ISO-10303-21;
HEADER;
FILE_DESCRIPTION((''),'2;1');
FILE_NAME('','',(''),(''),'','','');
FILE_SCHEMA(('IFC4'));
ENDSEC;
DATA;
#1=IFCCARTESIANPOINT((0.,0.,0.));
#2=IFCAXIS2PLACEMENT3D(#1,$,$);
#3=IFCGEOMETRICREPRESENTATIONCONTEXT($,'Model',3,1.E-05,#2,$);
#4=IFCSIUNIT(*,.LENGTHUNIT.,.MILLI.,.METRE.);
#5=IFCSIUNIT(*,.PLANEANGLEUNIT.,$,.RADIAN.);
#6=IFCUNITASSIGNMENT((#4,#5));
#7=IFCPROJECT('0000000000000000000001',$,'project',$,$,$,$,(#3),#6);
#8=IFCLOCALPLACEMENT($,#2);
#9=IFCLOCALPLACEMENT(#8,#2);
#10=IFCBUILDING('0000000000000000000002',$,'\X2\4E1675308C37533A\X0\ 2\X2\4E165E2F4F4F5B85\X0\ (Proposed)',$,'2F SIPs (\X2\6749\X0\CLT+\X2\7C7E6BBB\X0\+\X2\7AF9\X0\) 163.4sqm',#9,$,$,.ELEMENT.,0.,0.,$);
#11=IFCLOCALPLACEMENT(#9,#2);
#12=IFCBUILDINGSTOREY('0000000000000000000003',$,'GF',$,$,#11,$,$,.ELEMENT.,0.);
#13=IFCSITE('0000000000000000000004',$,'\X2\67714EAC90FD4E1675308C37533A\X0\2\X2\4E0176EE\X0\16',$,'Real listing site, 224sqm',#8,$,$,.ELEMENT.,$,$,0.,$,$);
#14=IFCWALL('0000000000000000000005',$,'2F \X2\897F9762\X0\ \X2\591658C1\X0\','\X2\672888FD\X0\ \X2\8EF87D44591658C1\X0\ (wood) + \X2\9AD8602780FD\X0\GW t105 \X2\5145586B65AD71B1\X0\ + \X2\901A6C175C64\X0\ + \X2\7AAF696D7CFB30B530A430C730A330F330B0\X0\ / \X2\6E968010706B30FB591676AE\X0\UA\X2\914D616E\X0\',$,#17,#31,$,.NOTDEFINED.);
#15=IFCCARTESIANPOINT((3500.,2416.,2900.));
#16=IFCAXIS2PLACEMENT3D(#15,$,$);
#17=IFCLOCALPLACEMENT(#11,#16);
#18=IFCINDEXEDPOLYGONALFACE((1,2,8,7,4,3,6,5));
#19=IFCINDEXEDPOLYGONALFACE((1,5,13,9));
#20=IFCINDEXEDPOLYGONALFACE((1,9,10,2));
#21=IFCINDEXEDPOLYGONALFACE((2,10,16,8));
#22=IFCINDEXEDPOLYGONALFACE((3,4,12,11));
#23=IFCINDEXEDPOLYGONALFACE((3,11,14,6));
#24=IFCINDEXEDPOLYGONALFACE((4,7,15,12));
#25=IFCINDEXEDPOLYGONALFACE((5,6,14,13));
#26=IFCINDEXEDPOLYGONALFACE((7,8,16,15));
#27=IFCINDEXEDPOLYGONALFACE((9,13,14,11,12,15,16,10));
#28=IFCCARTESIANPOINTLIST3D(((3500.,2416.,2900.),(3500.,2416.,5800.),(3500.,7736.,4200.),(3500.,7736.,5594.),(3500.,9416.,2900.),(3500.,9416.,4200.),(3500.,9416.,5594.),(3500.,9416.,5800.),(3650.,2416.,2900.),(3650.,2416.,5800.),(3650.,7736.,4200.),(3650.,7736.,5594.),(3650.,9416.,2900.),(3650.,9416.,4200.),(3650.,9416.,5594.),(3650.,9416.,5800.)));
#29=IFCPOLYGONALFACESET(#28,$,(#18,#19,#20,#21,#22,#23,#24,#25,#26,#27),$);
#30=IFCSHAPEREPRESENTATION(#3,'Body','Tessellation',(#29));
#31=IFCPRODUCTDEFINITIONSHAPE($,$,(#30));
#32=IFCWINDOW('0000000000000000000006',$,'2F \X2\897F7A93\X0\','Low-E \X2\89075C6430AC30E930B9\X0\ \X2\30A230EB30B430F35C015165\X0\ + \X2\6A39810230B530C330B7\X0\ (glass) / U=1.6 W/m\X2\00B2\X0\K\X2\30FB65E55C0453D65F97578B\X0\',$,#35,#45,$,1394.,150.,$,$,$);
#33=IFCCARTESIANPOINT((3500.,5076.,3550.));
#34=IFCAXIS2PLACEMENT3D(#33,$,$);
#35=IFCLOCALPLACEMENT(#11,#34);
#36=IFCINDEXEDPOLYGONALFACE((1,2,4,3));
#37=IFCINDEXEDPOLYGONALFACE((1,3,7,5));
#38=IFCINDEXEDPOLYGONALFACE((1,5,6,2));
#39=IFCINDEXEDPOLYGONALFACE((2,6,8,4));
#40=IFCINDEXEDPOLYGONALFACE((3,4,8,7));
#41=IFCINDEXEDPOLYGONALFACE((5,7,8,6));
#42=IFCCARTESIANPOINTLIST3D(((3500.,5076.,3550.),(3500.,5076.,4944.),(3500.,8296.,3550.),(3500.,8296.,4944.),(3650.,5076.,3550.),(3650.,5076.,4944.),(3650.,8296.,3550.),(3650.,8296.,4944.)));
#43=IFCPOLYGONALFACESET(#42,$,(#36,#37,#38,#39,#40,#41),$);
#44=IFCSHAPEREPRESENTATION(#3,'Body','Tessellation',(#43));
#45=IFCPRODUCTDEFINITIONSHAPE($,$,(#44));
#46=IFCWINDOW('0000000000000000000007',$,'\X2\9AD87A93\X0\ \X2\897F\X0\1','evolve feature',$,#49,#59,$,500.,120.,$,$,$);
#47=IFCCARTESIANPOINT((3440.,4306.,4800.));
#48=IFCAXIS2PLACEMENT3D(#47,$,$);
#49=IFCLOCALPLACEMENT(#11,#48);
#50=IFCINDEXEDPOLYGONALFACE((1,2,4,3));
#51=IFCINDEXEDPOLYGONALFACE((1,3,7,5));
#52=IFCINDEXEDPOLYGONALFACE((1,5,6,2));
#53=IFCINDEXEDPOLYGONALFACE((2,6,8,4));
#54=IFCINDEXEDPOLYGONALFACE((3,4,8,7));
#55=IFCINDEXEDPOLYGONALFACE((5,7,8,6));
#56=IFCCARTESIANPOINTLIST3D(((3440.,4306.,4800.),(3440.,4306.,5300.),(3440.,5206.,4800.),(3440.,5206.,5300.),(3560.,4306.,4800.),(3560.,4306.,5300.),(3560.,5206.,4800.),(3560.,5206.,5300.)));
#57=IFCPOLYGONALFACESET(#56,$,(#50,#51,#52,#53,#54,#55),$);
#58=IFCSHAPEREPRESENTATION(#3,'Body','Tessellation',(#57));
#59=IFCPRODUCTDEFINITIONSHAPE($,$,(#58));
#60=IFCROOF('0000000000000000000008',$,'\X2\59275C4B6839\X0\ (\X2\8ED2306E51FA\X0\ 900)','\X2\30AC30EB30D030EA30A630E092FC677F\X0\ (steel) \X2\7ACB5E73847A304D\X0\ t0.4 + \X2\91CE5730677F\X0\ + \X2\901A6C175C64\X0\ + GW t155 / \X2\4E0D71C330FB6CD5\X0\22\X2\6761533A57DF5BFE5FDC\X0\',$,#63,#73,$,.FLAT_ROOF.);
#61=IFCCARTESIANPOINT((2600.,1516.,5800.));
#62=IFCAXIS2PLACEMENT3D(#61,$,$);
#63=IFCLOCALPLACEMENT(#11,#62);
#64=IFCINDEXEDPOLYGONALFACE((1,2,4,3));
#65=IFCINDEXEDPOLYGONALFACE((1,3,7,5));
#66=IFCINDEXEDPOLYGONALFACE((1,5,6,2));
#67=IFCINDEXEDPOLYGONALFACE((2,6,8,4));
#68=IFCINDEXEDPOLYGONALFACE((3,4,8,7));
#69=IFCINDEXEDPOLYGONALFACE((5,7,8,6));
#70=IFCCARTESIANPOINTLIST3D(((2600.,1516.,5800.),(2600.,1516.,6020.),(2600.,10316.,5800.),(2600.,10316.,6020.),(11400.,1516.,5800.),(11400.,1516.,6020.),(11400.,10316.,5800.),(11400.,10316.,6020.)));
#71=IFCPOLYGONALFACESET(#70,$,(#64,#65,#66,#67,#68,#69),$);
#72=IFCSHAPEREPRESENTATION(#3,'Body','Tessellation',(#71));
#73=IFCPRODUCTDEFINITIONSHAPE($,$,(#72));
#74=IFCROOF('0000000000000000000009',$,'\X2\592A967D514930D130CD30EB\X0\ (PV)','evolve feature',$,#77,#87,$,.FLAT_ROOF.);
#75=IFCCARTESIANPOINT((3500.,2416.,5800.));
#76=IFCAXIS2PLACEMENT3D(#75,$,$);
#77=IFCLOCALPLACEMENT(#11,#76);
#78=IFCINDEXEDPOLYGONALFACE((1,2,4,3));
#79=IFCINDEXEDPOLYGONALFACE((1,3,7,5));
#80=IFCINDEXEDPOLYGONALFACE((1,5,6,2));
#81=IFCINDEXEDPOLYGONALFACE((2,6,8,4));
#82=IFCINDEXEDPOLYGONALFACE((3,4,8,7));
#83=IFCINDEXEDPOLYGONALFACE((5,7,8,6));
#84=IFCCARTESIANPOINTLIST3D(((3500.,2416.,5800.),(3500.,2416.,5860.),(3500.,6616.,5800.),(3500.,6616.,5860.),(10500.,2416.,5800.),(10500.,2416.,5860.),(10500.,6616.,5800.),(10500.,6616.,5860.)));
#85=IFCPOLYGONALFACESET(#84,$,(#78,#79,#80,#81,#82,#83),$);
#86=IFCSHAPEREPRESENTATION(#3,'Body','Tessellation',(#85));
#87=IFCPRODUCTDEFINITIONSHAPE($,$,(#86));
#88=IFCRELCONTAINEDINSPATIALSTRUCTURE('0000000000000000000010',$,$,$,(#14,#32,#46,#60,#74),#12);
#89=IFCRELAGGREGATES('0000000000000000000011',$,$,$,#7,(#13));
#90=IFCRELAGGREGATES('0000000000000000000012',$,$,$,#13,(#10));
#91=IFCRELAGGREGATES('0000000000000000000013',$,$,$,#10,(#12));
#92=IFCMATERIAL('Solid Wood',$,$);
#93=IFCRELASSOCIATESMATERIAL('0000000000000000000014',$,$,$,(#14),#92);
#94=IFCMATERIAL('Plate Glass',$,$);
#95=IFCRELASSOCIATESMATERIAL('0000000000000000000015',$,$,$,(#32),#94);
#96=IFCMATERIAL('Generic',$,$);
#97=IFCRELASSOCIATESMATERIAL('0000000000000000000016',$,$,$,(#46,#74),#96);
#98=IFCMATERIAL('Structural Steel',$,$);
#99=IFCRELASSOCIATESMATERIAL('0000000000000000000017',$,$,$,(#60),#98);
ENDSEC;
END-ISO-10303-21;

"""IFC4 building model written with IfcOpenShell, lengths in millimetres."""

from ifc_helpers import new_model, si_unit, frame, frame_2d, origin, place, context, project, spatial, rectangle, extrude, material, element, fill, save


model = new_model("IFC4")

# Units and contexts
model_context = context("Model", 3, precision=1e-05, world=origin())
ifc_project = project(units=[si_unit("LENGTHUNIT", "METRE", prefix="MILLI"), si_unit("PLANEANGLEUNIT", "RADIAN")], contexts=[model_context])

# Site, building, storey
site_placement = place(None, origin())
site = spatial("IfcSite", under=ifc_project, at=site_placement, Name="東京都世田谷区2丁目16", ObjectType="Real listing site, 224sqm", CompositionType="ELEMENT", RefElevation=0.0)
building_placement = place(site_placement, origin())
building = spatial("IfcBuilding", under=site, at=building_placement, Name="世田谷区 2世帯住宅 (Proposed)", ObjectType="2F SIPs (杉CLT+籾殻+竹) 163.4sqm", CompositionType="ELEMENT", ElevationOfRefHeight=0.0, ElevationOfTerrain=0.0)
storey_placement = place(building_placement, origin())
storey = spatial("IfcBuildingStorey", under=building, at=storey_placement, Name="GF", CompositionType="ELEMENT", Elevation=0.0)

# Shared definitions
ifc_material_1 = material(Name="Solid Wood")
ifc_material_2 = material(Name="Generic")

# Shared definitions
ifc_material_3 = material(Name="Plate Glass")

# Wall, openings, windows
wall_1_placement = place(storey_placement, frame((3500.0, 2416.0, 2900.0)))
wall_1 = element("IfcWall", 1, at=wall_1_placement, inside=storey, material=ifc_material_1, Name="2F 西面 外壁", Description="木製 軸組外壁 (wood) + 高性能GW t105 充填断熱 + 通気層 + 窯業系サイディング / 準耐火・外皮UA配慮", PredefinedType="NOTDEFINED", context=model_context, shape_type="SweptSolid", body=[
    extrude(rectangle(XDim=150.0, YDim=7000.0, at=frame_2d((75.0, 3500.0))), frame((3500.0, 2416.0, 2900.0)), (0.0, 0.0, 1.0), 2900.0),
])
opening_1_placement = place(storey_placement, frame((3500.0, 5076.0, 3550.0)))
opening_1 = element("IfcOpeningElement", 2, at=opening_1_placement, cuts=wall_1, PredefinedType="NOTDEFINED", context=model_context, shape_type="SweptSolid", body=[
    extrude(rectangle(XDim=150.0, YDim=3220.0, at=frame_2d((75.0, 1610.0))), frame((3500.0, 5076.0, 3550.0)), (0.0, 0.0, 1.0), 1394.0),
])
opening_2_placement = place(storey_placement, frame((3440.0, 4306.0, 4800.0)))
opening_2 = element("IfcOpeningElement", 3, at=opening_2_placement, cuts=wall_1, PredefinedType="NOTDEFINED", context=model_context, shape_type="SweptSolid", body=[
    extrude(rectangle(XDim=120.0, YDim=900.0, at=frame_2d((60.0, 450.0))), frame((3440.0, 4306.0, 4800.0)), (0.0, 0.0, 1.0), 500.0),
])
window_1_placement = place(storey_placement, frame((3500.0, 5076.0, 3550.0)))
window_1 = element("IfcWindow", 4, at=window_1_placement, inside=storey, material=ifc_material_3, Name="2F 西窓", Description="Low-E 複層ガラス アルゴン封入 + 樹脂サッシ (glass) / U=1.6 W/m²K・日射取得型", OverallHeight=1394.0, OverallWidth=150.0, context=model_context, shape_type="SweptSolid", body=[
    extrude(rectangle(XDim=150.0, YDim=3220.0, at=frame_2d((75.0, 1610.0))), frame((3500.0, 5076.0, 3550.0)), (0.0, 0.0, 1.0), 1394.0),
])
fill(opening_1, window_1)
window_2_placement = place(storey_placement, frame((3440.0, 4306.0, 4800.0)))
window_2 = element("IfcWindow", 5, at=window_2_placement, inside=storey, material=ifc_material_2, Name="高窓 西1", Description="evolve feature", OverallHeight=500.0, OverallWidth=120.0, context=model_context, shape_type="SweptSolid", body=[
    extrude(rectangle(XDim=120.0, YDim=900.0, at=frame_2d((60.0, 450.0))), frame((3440.0, 4306.0, 4800.0)), (0.0, 0.0, 1.0), 500.0),
])
fill(opening_2, window_2)

# Roofs
ifc_material_4 = material(Name="Structural Steel")
roof_1_placement = place(storey_placement, frame((2600.0, 1516.0, 5800.0)))
element("IfcRoof", 6, at=roof_1_placement, inside=storey, material=ifc_material_4, Name="大屋根 (軒の出 900)", Description="ガルバリウム鋼板 (steel) 立平葺き t0.4 + 野地板 + 通気層 + GW t155 / 不燃・法22条区域対応", PredefinedType="FLAT_ROOF", context=model_context, shape_type="SweptSolid", body=[
    extrude(rectangle(XDim=8800.0, YDim=8800.0, at=frame_2d((4400.0, 4400.0))), frame((2600.0, 1516.0, 5800.0)), (0.0, 0.0, 1.0), 220.0),
])
roof_2_placement = place(storey_placement, frame((3500.0, 2416.0, 5800.0)))
element("IfcRoof", 7, at=roof_2_placement, inside=storey, material=ifc_material_2, Name="太陽光パネル (PV)", Description="evolve feature", PredefinedType="FLAT_ROOF", context=model_context, shape_type="SweptSolid", body=[
    extrude(rectangle(XDim=7000.0, YDim=4200.0, at=frame_2d((3500.0, 2100.0))), frame((3500.0, 2416.0, 5800.0)), (0.0, 0.0, 1.0), 60.0),
])

save(model, "model.ifc")
